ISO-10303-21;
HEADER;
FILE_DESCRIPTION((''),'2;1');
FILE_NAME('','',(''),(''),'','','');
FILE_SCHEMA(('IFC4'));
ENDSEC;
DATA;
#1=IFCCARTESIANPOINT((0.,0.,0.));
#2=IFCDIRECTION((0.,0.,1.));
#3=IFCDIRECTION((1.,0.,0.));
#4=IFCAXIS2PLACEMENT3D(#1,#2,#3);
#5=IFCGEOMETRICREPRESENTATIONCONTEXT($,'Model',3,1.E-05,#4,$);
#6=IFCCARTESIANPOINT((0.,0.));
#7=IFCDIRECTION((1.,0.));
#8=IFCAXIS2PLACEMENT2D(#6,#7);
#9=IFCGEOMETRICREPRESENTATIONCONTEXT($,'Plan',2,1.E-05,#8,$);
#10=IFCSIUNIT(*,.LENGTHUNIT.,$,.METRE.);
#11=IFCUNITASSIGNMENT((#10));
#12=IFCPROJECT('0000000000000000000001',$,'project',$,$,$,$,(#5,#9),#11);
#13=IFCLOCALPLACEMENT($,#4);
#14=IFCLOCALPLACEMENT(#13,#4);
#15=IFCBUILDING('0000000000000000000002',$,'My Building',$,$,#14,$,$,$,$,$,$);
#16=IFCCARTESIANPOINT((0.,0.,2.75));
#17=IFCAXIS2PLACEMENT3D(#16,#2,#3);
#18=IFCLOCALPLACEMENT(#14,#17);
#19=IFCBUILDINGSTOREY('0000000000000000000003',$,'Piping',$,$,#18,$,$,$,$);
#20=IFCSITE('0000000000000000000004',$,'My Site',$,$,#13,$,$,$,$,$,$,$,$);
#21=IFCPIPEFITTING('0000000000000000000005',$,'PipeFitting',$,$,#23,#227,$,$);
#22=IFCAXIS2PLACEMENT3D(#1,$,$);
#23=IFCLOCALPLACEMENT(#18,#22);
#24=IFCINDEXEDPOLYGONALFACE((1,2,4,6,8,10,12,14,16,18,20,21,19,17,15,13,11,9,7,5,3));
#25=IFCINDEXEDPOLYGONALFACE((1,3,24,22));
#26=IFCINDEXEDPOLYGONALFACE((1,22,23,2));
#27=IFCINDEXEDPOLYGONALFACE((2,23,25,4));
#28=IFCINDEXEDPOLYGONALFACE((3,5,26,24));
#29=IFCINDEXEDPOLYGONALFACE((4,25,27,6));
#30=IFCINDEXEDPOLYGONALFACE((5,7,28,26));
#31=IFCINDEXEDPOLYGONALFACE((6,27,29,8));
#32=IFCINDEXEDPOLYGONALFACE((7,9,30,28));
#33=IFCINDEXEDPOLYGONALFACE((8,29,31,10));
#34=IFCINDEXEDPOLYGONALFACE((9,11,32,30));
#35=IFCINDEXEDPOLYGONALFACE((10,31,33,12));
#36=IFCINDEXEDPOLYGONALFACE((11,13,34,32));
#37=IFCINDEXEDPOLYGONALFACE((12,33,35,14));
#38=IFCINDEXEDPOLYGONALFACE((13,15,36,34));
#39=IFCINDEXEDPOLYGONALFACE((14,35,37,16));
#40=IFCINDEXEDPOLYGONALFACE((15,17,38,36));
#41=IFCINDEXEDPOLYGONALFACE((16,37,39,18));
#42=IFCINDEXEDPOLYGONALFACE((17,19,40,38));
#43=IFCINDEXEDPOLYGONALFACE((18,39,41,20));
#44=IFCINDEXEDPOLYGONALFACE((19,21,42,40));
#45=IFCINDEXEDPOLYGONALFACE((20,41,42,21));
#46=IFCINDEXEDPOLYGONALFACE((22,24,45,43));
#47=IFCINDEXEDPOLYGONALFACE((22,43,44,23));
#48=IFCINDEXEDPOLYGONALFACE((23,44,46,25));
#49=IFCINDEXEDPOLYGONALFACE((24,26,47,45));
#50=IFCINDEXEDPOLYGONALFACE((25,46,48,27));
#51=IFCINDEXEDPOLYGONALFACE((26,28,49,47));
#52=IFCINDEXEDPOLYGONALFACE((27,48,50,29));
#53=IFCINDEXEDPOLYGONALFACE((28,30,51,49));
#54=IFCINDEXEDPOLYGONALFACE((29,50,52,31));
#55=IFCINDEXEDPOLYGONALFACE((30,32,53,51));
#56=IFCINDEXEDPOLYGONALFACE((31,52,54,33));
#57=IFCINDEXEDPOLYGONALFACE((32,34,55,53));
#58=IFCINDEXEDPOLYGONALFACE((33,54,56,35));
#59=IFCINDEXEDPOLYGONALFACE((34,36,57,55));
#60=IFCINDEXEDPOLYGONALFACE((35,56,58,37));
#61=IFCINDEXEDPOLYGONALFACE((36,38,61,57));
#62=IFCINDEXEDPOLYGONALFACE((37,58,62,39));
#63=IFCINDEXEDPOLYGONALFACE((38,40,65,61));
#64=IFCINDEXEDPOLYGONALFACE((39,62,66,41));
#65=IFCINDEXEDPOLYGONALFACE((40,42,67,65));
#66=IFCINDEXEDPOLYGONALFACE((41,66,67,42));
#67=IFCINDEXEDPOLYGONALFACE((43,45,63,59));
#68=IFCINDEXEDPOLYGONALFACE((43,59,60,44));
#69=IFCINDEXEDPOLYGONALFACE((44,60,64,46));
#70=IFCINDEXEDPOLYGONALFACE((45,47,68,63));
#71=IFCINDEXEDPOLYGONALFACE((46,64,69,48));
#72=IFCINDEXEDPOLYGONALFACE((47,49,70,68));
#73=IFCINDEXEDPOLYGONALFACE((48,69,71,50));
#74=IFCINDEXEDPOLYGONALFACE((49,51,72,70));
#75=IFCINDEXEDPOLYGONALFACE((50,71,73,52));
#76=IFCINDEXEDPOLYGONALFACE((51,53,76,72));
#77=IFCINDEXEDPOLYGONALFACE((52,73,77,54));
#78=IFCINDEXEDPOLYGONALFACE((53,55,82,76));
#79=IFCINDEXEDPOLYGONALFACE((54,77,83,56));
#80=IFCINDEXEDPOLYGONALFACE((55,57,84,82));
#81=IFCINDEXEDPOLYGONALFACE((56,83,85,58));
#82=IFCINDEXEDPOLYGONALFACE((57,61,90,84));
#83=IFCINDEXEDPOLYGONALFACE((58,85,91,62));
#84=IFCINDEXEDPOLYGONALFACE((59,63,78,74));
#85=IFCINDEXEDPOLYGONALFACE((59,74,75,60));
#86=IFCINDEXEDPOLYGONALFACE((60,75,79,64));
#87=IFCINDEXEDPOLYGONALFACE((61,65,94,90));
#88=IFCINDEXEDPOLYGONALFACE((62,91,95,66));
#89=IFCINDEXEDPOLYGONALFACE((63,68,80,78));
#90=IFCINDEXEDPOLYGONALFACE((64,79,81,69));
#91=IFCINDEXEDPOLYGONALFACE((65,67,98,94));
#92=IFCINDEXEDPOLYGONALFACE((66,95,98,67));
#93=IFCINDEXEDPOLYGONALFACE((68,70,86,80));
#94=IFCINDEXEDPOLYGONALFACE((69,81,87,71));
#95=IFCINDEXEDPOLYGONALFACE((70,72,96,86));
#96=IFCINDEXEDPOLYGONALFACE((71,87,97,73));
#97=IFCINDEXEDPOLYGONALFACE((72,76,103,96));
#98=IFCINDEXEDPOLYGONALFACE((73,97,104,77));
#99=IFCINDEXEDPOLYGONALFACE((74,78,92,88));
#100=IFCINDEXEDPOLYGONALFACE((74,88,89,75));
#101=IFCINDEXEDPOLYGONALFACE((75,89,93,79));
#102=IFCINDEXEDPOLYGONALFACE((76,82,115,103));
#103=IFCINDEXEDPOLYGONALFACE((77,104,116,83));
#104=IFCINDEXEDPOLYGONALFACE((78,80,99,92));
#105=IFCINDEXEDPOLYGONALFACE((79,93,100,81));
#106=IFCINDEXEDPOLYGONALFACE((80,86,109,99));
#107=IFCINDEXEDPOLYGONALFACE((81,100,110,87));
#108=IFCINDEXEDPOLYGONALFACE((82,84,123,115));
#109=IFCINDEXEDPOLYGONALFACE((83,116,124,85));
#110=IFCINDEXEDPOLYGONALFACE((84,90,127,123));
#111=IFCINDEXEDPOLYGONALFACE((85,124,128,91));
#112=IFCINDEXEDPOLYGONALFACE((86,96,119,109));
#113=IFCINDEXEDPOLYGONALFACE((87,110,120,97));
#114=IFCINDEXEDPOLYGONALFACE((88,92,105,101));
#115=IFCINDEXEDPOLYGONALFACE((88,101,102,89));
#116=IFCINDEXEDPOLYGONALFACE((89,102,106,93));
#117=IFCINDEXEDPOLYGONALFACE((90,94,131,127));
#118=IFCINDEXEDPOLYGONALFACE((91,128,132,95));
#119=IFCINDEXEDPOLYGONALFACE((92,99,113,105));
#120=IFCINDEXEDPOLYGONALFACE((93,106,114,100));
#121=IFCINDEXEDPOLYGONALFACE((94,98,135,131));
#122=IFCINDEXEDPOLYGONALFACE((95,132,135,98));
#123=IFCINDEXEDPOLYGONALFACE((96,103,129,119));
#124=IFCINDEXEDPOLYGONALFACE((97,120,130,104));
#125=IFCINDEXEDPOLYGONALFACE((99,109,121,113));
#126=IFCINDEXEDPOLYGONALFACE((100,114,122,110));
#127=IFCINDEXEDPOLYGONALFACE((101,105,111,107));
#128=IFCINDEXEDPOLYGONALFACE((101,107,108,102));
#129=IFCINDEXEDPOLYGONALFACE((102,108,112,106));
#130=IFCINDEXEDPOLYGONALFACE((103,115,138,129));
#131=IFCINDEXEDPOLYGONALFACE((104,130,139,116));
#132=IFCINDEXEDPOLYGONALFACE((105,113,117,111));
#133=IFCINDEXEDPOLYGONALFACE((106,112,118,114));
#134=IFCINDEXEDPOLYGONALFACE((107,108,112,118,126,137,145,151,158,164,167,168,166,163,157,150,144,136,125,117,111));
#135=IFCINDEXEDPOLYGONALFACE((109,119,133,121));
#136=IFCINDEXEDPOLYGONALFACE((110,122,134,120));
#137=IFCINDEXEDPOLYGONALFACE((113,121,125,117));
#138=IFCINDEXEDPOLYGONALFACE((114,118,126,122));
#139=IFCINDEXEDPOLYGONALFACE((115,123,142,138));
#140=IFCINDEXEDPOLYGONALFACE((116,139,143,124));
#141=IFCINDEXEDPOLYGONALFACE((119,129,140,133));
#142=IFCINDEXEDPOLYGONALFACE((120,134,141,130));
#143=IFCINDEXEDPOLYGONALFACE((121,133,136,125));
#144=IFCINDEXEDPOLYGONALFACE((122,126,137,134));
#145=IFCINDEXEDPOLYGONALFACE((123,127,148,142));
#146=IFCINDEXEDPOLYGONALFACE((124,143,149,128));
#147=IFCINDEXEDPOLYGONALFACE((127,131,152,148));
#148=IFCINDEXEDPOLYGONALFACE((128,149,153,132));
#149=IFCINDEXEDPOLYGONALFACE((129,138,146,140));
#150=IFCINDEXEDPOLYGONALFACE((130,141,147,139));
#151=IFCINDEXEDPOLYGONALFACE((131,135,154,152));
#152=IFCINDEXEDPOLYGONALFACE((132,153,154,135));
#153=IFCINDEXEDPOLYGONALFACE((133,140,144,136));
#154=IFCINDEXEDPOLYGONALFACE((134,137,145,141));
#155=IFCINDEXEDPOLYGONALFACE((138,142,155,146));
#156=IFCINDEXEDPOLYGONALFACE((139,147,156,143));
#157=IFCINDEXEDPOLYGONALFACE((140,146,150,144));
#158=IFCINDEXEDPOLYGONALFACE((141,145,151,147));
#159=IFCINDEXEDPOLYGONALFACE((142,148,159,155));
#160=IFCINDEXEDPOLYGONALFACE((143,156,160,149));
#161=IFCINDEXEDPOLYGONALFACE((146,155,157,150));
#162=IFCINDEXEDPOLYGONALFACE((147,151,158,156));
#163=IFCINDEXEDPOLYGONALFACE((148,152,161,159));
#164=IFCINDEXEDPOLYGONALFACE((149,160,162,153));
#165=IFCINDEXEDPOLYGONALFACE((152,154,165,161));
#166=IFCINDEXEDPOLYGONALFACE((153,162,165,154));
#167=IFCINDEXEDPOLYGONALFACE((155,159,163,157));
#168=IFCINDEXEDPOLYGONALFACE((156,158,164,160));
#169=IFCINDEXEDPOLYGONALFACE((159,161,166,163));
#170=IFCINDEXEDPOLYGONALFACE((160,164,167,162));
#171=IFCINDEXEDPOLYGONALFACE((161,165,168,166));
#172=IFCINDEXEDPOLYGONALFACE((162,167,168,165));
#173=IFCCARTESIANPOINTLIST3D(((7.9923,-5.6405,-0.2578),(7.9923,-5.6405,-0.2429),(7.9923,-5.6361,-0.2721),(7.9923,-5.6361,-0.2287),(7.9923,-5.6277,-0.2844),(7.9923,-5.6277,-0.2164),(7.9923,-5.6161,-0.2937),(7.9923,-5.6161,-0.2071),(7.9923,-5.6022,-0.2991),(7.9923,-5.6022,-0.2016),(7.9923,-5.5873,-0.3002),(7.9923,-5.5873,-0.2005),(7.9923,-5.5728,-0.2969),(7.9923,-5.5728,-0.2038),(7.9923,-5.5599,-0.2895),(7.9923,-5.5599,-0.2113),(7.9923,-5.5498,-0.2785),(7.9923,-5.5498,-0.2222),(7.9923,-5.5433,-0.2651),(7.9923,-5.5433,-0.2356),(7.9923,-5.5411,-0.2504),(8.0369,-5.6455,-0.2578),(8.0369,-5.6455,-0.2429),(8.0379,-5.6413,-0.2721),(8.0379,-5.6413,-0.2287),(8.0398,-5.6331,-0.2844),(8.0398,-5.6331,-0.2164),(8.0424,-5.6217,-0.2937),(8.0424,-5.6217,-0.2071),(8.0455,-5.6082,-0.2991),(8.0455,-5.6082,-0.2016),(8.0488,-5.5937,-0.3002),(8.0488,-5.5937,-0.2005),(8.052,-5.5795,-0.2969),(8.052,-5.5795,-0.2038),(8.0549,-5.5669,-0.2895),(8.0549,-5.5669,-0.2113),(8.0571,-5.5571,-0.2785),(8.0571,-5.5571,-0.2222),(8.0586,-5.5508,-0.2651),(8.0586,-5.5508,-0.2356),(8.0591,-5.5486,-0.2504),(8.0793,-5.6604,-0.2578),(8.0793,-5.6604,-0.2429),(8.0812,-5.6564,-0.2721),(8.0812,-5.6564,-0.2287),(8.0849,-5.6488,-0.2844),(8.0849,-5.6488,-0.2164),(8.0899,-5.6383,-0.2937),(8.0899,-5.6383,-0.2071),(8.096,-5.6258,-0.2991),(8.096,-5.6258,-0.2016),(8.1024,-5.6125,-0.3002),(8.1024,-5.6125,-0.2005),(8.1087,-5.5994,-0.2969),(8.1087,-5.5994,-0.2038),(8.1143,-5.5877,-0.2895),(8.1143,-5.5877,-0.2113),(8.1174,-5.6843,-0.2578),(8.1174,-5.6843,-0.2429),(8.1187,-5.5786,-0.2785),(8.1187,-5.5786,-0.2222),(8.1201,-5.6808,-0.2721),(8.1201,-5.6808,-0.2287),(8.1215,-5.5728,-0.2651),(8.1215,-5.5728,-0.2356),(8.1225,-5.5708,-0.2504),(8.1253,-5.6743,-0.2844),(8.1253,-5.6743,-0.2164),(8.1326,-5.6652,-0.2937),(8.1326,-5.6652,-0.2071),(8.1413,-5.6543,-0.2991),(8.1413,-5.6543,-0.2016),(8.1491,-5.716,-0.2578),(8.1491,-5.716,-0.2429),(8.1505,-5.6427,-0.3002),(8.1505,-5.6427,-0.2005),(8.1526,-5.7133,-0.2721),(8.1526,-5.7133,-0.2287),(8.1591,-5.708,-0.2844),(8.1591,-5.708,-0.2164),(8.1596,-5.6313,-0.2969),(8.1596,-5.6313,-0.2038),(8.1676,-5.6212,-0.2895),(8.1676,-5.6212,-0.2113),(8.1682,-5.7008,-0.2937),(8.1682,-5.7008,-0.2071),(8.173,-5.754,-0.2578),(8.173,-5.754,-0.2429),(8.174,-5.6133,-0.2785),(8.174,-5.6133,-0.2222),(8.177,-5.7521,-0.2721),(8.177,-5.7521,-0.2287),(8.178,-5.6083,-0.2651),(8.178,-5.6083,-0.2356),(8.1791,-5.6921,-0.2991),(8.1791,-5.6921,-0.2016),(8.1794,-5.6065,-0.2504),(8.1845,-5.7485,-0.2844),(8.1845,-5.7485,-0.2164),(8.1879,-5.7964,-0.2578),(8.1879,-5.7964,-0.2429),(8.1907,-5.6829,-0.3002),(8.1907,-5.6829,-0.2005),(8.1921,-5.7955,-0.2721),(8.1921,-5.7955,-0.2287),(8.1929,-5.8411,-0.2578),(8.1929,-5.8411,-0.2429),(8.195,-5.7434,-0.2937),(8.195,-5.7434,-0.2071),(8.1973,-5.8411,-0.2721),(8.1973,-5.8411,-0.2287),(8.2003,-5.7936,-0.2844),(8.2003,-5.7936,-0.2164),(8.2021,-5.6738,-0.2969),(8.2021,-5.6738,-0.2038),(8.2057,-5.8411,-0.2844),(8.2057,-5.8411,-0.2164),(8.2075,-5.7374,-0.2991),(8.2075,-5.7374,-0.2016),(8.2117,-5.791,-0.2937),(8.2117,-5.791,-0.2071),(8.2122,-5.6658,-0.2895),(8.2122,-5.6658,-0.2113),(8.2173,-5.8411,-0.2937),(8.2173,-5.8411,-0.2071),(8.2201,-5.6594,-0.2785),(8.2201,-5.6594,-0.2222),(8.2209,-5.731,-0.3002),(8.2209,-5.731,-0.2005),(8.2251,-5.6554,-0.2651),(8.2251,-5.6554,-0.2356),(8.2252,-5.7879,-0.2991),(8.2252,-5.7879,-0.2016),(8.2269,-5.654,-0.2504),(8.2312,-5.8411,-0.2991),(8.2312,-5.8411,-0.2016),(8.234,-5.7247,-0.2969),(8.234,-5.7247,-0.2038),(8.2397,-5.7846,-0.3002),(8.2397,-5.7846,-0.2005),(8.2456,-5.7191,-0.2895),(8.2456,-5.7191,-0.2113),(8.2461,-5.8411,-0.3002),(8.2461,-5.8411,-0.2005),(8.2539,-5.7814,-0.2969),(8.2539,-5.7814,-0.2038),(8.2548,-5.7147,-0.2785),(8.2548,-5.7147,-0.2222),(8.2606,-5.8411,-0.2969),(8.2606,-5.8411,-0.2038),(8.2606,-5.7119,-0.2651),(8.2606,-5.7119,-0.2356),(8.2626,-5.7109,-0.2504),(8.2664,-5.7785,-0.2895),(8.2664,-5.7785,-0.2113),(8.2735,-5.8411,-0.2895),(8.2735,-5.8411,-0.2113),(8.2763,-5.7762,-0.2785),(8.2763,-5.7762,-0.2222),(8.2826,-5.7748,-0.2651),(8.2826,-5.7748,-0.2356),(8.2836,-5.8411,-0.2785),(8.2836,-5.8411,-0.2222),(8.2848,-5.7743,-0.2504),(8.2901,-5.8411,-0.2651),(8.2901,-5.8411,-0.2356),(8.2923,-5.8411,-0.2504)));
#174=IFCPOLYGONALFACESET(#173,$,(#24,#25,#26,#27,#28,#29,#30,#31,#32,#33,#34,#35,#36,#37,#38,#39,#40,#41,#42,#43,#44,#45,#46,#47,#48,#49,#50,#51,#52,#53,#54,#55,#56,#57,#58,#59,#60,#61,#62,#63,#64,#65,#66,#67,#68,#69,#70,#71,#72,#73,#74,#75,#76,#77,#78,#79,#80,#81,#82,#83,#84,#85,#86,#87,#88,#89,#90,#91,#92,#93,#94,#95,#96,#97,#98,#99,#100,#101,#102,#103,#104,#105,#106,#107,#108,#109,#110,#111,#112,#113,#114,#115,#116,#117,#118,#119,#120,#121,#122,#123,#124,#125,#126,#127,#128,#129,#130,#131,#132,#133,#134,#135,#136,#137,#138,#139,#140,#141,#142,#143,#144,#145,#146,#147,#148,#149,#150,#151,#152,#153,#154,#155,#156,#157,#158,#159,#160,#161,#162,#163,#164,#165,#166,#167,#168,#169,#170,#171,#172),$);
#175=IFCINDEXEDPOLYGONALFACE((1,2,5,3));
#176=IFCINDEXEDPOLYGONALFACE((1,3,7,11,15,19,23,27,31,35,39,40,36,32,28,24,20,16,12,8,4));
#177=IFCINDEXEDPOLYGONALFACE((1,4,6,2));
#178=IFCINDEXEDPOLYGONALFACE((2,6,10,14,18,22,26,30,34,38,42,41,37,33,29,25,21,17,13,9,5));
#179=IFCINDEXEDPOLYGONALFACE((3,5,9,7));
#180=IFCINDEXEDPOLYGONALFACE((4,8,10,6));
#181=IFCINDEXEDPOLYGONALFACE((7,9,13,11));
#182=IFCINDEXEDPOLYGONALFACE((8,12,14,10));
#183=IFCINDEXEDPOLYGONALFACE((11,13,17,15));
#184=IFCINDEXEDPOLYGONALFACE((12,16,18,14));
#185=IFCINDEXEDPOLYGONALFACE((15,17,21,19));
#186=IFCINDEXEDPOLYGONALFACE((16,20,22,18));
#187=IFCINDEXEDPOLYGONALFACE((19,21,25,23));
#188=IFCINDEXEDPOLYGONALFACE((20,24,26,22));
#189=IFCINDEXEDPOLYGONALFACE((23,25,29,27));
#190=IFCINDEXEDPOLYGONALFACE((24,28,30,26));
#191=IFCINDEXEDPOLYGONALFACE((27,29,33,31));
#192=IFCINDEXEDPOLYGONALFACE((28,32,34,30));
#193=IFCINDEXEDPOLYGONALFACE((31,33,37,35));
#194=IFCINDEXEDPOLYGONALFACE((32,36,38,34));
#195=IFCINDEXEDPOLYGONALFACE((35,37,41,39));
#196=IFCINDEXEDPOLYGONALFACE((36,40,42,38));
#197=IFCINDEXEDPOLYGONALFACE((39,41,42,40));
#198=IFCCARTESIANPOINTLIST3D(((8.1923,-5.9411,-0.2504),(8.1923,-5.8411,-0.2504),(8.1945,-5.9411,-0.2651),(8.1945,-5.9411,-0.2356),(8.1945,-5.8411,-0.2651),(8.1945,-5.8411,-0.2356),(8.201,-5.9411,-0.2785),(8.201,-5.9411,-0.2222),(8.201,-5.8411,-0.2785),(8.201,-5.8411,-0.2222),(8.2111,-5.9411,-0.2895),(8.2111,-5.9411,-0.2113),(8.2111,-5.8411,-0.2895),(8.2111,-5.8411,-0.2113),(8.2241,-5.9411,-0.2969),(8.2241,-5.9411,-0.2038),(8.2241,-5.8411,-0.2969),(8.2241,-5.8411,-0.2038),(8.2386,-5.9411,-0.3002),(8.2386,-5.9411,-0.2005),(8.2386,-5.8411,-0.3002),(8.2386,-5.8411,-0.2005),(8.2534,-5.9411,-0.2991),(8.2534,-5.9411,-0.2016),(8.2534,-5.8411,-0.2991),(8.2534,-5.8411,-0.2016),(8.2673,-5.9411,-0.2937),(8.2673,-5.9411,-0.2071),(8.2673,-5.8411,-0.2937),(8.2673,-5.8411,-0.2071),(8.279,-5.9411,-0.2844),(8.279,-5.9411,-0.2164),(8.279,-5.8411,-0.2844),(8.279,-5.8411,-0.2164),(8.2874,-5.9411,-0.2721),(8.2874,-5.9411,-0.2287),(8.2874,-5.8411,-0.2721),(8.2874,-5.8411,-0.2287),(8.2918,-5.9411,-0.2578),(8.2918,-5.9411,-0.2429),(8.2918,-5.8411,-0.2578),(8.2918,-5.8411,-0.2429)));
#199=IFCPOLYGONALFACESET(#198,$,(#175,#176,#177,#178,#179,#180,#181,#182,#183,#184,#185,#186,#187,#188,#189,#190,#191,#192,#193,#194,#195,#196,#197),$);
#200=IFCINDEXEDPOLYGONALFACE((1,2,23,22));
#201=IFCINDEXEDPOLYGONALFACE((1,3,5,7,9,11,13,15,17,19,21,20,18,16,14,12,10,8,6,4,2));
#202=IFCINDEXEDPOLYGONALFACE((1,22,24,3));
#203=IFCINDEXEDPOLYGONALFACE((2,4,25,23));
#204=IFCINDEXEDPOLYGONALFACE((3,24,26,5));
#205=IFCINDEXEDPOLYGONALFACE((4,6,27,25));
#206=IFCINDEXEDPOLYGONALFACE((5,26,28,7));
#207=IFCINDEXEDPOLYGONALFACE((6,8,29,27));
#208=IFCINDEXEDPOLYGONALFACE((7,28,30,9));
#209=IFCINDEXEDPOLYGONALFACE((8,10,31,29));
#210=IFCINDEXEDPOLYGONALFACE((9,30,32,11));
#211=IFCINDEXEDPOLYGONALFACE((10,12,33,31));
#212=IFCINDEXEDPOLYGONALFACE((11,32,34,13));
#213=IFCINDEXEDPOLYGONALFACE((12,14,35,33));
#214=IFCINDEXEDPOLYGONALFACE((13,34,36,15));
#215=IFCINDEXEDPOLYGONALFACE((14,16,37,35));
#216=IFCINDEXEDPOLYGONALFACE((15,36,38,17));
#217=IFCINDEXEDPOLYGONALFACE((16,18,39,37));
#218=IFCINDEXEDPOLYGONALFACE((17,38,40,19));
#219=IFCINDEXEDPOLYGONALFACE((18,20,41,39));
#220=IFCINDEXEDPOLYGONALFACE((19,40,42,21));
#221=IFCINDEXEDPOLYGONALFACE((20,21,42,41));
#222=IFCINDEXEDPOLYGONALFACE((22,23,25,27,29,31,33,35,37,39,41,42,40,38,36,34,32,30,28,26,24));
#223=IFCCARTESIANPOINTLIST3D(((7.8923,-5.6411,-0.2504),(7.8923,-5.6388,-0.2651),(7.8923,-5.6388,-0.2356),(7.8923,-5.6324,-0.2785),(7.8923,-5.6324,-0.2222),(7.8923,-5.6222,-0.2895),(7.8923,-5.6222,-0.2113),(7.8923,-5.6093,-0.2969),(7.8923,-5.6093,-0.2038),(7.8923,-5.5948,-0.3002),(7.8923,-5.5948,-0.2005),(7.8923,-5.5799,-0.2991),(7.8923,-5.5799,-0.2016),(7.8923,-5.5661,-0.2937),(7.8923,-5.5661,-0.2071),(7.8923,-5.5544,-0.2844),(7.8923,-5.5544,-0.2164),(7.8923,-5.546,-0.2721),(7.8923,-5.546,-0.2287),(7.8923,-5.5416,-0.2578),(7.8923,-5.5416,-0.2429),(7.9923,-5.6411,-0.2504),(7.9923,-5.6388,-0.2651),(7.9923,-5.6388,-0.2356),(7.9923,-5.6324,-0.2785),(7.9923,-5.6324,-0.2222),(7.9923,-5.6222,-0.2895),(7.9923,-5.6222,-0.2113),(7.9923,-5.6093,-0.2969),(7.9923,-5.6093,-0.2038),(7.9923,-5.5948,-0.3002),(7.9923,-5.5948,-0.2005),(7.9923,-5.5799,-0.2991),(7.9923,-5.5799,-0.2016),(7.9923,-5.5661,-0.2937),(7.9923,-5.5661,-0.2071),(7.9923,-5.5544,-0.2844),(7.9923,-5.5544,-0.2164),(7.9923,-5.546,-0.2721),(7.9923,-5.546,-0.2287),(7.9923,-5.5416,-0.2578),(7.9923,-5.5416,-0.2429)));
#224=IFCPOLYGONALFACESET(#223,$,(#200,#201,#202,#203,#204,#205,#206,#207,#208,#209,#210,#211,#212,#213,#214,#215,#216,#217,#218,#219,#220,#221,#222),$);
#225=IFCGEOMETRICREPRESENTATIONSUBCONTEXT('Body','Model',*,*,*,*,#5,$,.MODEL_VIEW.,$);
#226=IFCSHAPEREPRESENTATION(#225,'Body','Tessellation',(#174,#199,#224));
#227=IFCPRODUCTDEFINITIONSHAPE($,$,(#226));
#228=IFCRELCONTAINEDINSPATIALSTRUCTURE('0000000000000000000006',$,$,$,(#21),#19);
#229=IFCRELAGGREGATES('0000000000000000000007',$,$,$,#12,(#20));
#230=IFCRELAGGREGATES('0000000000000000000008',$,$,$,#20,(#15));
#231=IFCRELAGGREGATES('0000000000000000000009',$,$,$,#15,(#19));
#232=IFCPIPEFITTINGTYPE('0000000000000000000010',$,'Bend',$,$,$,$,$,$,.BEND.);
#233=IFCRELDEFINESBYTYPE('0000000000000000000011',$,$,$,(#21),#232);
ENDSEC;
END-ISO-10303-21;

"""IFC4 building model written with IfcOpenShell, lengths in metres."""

from ifc_helpers import new_model, entity, si_unit, frame, origin_with_axes, origin_2d_with_axis, place, context, subcontext, project, spatial, circle, extrude, source, transform, mapped, type_object, type_shapes, element, save


model = new_model("IFC4")

# Units and contexts
model_context = context("Model", 3, precision=1e-05, world=origin_with_axes())
plan_context = context("Plan", 2, precision=1e-05, world=origin_2d_with_axis())
body_context = subcontext(model_context, "Body", "Model", "MODEL_VIEW")
ifc_project = project(units=[si_unit("LENGTHUNIT", "METRE")], contexts=[model_context, plan_context])

# Site, building, storey
site_placement = place(None, origin_with_axes())
site = spatial("IfcSite", under=ifc_project, at=site_placement, Name="My Site")
building_placement = place(site_placement, origin_with_axes())
building = spatial("IfcBuilding", under=site, at=building_placement, Name="My Building")
storey_placement = place(building_placement, frame((0.0, 0.0, 2.75), z_axis=(0.0, 0.0, 1.0), x_axis=(1.0, 0.0, 0.0)))
storey = spatial("IfcBuildingStorey", under=building, at=storey_placement, Name="Piping")

# Pipe fitting
pipe_fitting_type = type_object("IfcPipeFittingType", Name="Bend", PredefinedType="BEND")
shared_shape = source(origin_with_axes(), body_context, "Body", "SolidModel", [
    entity("IfcSweptDiskSolid", entity("IfcIndexedPolyCurve", entity("IfcCartesianPointList3D", [[0.0, 0.0, -0.1], [0.0732, 0.0, -0.2768], [0.25, 0.0, -0.35]]), [entity("IfcArcIndex", [1, 2, 3])]), 0.05),
    extrude(circle(Radius=0.05), origin_with_axes(), (0.0, 0.0, -1.0), 0.1),
    extrude(circle(Radius=0.05), frame((0.25, 0.0, -0.35), z_axis=(1.0, 0.0, 0.0), x_axis=(0.0, 0.0, 1.0)), (0.0, 0.0, 1.0), 0.1),
])
type_shapes(pipe_fitting_type, [shared_shape])
for number, where, z_axis, x_axis, name in (
    (1, (8.2423, -5.9411, -0.2504), (0.0, -1.0, 0.0), (-1.0, 0.0, 0.0), "PipeFitting"),
):
    element("IfcPipeFitting", number, at=place(storey_placement, frame(where, z_axis=z_axis, x_axis=x_axis)), inside=storey, type_object=pipe_fitting_type, Name=name, context=body_context, shape_type="MappedRepresentation", body=[
        mapped(shared_shape, transform((0.0, 0.0, 0.0), x_axis=(1.0, 0.0, 0.0), y_axis=(0.0, 1.0, 0.0), z_axis=(0.0, 0.0, 1.0), scale=1.0)),
    ])

save(model, "model.ifc")
